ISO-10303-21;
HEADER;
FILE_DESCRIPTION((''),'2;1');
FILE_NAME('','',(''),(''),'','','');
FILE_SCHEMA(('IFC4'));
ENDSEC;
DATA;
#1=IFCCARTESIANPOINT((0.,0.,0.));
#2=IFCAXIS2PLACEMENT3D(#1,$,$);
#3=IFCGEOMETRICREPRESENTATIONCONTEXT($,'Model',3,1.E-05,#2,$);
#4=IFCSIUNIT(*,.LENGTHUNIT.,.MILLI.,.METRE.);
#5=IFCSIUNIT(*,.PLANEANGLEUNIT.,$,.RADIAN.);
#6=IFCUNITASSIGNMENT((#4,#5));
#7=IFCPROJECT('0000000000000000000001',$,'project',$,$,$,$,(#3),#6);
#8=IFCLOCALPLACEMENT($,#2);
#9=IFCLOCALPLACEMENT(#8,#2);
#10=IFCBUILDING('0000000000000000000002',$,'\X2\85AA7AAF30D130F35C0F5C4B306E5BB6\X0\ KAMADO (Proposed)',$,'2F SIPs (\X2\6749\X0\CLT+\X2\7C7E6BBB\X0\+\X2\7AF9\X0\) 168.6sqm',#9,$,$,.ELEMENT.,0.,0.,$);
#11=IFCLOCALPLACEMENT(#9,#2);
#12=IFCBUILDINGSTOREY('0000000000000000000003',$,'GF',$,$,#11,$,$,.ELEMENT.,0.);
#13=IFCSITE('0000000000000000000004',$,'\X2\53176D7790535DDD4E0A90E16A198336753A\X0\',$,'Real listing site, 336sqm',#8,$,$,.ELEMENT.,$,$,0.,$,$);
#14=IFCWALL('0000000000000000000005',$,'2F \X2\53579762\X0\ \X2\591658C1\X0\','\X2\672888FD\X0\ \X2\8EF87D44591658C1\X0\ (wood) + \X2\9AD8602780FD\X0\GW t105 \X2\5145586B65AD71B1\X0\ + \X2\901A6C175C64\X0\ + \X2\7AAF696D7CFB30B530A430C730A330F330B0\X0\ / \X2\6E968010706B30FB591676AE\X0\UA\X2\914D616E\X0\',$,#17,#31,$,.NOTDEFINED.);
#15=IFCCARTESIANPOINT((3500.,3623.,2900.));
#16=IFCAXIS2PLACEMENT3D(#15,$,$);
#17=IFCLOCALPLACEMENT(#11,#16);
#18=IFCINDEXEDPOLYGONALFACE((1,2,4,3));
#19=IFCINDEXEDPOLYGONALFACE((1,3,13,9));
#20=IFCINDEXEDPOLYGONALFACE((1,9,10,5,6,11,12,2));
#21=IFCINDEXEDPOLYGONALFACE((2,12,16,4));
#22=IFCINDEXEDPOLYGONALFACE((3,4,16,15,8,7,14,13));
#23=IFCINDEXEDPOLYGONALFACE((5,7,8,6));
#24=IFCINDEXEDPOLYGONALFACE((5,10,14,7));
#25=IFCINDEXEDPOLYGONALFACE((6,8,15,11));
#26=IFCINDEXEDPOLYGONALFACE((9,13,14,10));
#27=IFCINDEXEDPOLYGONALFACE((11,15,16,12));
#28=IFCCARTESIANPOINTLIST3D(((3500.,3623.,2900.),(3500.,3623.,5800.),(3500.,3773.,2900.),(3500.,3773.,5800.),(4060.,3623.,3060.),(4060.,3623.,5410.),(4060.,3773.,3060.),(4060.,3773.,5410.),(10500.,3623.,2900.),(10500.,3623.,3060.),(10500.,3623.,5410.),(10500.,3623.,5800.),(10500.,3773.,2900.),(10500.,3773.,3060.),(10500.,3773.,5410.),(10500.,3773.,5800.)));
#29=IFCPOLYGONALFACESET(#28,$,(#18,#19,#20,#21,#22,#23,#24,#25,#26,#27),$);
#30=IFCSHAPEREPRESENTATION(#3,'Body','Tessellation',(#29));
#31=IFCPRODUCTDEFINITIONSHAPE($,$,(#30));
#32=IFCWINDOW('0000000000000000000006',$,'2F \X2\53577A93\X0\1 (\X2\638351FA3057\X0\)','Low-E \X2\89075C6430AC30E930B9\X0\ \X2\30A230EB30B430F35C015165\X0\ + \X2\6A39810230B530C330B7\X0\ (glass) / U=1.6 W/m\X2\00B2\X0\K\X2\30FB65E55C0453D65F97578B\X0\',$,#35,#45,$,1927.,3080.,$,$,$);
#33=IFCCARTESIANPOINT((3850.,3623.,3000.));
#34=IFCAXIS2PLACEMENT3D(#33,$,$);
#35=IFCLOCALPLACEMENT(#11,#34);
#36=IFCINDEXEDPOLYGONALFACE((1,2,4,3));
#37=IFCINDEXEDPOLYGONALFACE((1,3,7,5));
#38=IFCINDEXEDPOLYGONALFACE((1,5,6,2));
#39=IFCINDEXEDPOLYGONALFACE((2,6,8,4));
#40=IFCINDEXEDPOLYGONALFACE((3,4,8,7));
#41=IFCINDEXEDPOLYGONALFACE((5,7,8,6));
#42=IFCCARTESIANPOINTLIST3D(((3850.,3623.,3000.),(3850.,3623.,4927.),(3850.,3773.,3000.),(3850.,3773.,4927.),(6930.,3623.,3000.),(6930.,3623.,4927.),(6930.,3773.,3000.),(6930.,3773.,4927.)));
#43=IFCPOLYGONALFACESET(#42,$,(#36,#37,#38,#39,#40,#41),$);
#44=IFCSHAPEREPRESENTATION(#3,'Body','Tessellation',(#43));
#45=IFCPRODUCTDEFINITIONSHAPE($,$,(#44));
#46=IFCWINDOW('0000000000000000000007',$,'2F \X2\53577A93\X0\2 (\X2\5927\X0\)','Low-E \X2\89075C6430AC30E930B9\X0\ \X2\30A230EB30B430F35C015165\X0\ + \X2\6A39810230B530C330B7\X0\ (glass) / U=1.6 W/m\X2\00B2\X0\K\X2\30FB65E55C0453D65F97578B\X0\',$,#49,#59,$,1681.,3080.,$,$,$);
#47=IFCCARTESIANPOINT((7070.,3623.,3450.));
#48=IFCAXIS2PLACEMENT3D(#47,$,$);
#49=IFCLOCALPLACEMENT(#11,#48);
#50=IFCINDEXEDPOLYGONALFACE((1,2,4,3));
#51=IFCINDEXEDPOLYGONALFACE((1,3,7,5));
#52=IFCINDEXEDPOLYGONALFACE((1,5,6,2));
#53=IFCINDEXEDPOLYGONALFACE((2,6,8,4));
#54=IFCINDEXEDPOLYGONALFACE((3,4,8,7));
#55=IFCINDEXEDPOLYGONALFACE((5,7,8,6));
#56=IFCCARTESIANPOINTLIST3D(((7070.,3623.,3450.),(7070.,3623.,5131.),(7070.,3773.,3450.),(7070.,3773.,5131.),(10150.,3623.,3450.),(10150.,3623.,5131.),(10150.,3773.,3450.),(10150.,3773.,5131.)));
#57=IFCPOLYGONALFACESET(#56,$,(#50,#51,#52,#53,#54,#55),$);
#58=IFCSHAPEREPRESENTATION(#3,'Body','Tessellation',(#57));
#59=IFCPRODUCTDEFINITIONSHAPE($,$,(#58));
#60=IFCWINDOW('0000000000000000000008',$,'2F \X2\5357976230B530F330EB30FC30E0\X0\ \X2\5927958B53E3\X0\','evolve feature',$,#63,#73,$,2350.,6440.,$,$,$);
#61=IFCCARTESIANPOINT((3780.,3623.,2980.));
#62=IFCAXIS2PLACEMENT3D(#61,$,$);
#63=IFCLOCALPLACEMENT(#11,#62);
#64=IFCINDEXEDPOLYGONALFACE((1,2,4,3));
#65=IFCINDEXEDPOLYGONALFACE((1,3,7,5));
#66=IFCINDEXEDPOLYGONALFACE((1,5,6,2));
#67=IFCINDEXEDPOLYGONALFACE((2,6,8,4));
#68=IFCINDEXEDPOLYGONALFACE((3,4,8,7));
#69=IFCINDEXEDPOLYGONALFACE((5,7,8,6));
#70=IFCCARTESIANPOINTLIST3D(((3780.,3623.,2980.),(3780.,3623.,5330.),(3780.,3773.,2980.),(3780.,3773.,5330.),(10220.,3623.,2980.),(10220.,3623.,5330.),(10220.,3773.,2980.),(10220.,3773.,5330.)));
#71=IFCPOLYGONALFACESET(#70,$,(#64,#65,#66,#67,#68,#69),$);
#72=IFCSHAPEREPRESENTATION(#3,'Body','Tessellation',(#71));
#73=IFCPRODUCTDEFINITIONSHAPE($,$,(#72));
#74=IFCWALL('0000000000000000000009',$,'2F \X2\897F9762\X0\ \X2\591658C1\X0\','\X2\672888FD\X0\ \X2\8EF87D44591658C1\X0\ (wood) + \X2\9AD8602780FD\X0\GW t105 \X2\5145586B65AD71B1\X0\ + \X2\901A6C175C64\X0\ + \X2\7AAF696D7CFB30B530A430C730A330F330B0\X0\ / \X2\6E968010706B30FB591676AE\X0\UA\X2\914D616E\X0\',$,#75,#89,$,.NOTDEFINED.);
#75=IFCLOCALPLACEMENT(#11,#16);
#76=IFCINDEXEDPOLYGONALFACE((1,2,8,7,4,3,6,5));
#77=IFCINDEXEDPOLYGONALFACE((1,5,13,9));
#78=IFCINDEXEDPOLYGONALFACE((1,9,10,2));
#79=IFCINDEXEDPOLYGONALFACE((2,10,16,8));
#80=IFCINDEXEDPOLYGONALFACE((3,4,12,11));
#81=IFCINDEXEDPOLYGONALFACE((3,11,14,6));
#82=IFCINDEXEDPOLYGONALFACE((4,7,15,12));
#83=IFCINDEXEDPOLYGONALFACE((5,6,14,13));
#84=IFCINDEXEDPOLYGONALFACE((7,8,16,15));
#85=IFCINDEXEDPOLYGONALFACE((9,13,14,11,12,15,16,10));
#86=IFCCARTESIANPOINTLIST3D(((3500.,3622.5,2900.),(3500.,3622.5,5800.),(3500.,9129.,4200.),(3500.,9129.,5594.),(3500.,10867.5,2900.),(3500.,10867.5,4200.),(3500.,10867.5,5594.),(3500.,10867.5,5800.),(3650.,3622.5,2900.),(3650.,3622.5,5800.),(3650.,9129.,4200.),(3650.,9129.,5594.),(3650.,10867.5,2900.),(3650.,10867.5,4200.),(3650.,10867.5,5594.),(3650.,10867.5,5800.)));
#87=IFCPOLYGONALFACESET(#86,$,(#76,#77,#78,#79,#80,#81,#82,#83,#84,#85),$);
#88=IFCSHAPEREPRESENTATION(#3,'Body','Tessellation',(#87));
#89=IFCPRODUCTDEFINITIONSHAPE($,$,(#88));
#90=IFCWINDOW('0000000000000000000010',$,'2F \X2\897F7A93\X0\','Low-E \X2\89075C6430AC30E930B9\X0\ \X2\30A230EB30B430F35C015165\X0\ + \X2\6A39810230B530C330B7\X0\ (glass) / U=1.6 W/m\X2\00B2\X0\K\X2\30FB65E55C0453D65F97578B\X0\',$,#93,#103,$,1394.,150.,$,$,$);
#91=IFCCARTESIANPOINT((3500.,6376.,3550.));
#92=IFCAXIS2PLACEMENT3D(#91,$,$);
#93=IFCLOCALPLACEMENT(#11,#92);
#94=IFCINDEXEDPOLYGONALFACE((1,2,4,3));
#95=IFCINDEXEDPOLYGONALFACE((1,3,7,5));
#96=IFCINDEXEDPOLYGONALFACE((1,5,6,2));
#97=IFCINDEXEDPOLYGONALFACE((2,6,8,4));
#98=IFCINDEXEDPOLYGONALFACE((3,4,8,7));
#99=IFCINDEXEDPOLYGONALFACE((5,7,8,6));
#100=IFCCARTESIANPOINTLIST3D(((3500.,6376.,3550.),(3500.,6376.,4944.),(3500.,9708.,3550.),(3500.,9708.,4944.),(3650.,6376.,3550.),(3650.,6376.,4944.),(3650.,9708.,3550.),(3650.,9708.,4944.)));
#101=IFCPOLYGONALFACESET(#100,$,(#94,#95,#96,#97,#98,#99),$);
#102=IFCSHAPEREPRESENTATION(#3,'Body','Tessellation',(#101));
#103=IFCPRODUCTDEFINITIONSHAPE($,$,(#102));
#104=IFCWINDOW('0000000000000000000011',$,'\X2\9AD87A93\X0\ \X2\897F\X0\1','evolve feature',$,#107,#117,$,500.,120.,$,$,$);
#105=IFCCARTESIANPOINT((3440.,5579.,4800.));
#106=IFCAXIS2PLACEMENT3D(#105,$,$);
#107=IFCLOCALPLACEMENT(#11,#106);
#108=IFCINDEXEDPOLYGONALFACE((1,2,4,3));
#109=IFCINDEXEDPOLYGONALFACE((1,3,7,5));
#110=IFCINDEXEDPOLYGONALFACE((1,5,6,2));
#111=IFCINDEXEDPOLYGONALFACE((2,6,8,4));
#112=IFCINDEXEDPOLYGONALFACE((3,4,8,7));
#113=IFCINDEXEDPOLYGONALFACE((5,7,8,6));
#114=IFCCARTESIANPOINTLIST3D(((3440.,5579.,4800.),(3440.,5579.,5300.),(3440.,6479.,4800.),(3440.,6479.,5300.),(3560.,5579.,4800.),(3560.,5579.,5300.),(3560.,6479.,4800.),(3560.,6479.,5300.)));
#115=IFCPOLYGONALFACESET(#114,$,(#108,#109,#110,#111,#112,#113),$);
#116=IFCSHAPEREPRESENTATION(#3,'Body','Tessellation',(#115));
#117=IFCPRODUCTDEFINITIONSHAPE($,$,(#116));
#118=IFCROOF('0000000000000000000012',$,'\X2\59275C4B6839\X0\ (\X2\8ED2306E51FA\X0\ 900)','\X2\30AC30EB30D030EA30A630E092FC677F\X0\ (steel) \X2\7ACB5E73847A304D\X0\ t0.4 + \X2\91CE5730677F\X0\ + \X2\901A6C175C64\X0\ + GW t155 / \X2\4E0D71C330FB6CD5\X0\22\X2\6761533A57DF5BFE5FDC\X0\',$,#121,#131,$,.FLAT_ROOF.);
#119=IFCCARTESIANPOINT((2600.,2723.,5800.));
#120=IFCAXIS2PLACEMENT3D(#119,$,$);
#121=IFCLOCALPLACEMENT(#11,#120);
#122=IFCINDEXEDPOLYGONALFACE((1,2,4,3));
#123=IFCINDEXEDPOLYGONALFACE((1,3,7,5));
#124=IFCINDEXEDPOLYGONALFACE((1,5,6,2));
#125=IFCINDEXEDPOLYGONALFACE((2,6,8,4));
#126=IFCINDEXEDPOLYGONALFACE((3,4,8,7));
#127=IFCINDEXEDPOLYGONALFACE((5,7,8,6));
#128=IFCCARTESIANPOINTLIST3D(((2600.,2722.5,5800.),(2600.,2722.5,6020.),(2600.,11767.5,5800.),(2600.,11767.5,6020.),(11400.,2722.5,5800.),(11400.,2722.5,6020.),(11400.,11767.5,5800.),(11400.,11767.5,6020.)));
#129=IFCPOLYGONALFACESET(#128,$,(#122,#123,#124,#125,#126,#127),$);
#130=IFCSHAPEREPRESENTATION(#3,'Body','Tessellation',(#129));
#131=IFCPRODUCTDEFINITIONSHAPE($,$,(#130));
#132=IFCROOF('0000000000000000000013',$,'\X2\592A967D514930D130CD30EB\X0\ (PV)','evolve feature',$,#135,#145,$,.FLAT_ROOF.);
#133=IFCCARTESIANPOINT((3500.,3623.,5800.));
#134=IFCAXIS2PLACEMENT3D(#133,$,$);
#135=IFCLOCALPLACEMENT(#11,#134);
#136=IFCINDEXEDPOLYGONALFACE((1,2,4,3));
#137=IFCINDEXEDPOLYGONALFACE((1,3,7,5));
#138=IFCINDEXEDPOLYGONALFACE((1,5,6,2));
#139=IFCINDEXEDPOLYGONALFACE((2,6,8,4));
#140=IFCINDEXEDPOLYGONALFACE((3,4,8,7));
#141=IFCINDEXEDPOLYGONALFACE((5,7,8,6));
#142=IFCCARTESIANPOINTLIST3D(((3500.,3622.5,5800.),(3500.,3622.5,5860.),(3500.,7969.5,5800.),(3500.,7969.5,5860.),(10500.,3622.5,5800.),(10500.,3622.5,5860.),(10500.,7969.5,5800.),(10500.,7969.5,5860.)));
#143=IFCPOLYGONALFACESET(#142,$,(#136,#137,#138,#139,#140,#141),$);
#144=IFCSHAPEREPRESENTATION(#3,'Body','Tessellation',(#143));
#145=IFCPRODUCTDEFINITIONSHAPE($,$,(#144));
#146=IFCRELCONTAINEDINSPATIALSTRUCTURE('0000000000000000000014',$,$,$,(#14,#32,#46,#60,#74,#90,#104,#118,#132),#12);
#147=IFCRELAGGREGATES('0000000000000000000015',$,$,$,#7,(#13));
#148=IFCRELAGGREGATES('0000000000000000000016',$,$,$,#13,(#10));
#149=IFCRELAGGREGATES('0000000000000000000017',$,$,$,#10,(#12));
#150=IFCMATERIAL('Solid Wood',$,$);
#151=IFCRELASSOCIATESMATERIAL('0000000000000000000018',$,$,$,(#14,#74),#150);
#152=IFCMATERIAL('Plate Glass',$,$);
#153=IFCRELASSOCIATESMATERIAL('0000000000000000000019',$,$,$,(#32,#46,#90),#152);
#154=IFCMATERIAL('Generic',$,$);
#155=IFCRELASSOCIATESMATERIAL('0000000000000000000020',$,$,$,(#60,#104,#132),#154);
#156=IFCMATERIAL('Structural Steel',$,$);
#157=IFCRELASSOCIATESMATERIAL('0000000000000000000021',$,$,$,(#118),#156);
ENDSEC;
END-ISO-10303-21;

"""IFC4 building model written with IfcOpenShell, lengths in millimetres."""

from ifc_helpers import new_model, si_unit, frame, frame_2d, origin, place, context, project, spatial, rectangle, extrude, material, element, fill, save


model = new_model("IFC4")

# Units and contexts
model_context = context("Model", 3, precision=1e-05, world=origin())
ifc_project = project(units=[si_unit("LENGTHUNIT", "METRE", prefix="MILLI"), si_unit("PLANEANGLEUNIT", "RADIAN")], contexts=[model_context])

# Site, building, storey
site_placement = place(None, origin())
site = spatial("IfcSite", under=ifc_project, at=site_placement, Name="北海道川上郡標茶町", ObjectType="Real listing site, 336sqm", CompositionType="ELEMENT", RefElevation=0.0)
building_placement = place(site_placement, origin())
building = spatial("IfcBuilding", under=site, at=building_placement, Name="薪窯パン小屋の家 KAMADO (Proposed)", ObjectType="2F SIPs (杉CLT+籾殻+竹) 168.6sqm", CompositionType="ELEMENT", ElevationOfRefHeight=0.0, ElevationOfTerrain=0.0)
storey_placement = place(building_placement, origin())
storey = spatial("IfcBuildingStorey", under=building, at=storey_placement, Name="GF", CompositionType="ELEMENT", Elevation=0.0)

# Shared definitions
ifc_material_1 = material(Name="Solid Wood")
ifc_material_2 = material(Name="Generic")

# Shared definitions
ifc_material_3 = material(Name="Plate Glass")

# Walls, openings, windows
wall_1_placement = place(storey_placement, frame((3500.0, 3623.0, 2900.0)))
wall_1 = element("IfcWall", 1, at=wall_1_placement, inside=storey, material=ifc_material_1, Name="2F 南面 外壁", Description="木製 軸組外壁 (wood) + 高性能GW t105 充填断熱 + 通気層 + 窯業系サイディング / 準耐火・外皮UA配慮", PredefinedType="NOTDEFINED", context=model_context, shape_type="SweptSolid", body=[
    extrude(rectangle(XDim=7000.0, YDim=150.0, at=frame_2d((3500.0, 75.0))), frame((3500.0, 3623.0, 2900.0)), (0.0, 0.0, 1.0), 2900.0),
])
opening_1_placement = place(storey_placement, frame((3850.0, 3623.0, 3000.0)))
opening_1 = element("IfcOpeningElement", 2, at=opening_1_placement, cuts=wall_1, PredefinedType="NOTDEFINED", context=model_context, shape_type="SweptSolid", body=[
    extrude(rectangle(XDim=3080.0, YDim=150.0, at=frame_2d((1540.0, 75.0))), frame((3850.0, 3623.0, 3000.0)), (0.0, 0.0, 1.0), 1927.0),
])
opening_2_placement = place(storey_placement, frame((7070.0, 3623.0, 3450.0)))
opening_2 = element("IfcOpeningElement", 3, at=opening_2_placement, cuts=wall_1, PredefinedType="NOTDEFINED", context=model_context, shape_type="SweptSolid", body=[
    extrude(rectangle(XDim=3080.0, YDim=150.0, at=frame_2d((1540.0, 75.0))), frame((7070.0, 3623.0, 3450.0)), (0.0, 0.0, 1.0), 1681.0),
])
opening_3_placement = place(storey_placement, frame((3780.0, 3623.0, 2980.0)))
opening_3 = element("IfcOpeningElement", 4, at=opening_3_placement, cuts=wall_1, PredefinedType="NOTDEFINED", context=model_context, shape_type="SweptSolid", body=[
    extrude(rectangle(XDim=6440.0, YDim=150.0, at=frame_2d((3220.0, 75.0))), frame((3780.0, 3623.0, 2980.0)), (0.0, 0.0, 1.0), 2350.0),
])
window_1_placement = place(storey_placement, frame((3850.0, 3623.0, 3000.0)))
window_1 = element("IfcWindow", 5, at=window_1_placement, inside=storey, material=ifc_material_3, Name="2F 南窓1 (掃出し)", Description="Low-E 複層ガラス アルゴン封入 + 樹脂サッシ (glass) / U=1.6 W/m²K・日射取得型", OverallHeight=1927.0, OverallWidth=3080.0, context=model_context, shape_type="SweptSolid", body=[
    extrude(rectangle(XDim=3080.0, YDim=150.0, at=frame_2d((1540.0, 75.0))), frame((3850.0, 3623.0, 3000.0)), (0.0, 0.0, 1.0), 1927.0),
])
fill(opening_1, window_1)
window_2_placement = place(storey_placement, frame((7070.0, 3623.0, 3450.0)))
window_2 = element("IfcWindow", 6, at=window_2_placement, inside=storey, material=ifc_material_3, Name="2F 南窓2 (大)", Description="Low-E 複層ガラス アルゴン封入 + 樹脂サッシ (glass) / U=1.6 W/m²K・日射取得型", OverallHeight=1681.0, OverallWidth=3080.0, context=model_context, shape_type="SweptSolid", body=[
    extrude(rectangle(XDim=3080.0, YDim=150.0, at=frame_2d((1540.0, 75.0))), frame((7070.0, 3623.0, 3450.0)), (0.0, 0.0, 1.0), 1681.0),
])
fill(opening_2, window_2)
window_3_placement = place(storey_placement, frame((3780.0, 3623.0, 2980.0)))
window_3 = element("IfcWindow", 7, at=window_3_placement, inside=storey, material=ifc_material_2, Name="2F 南面サンルーム 大開口", Description="evolve feature", OverallHeight=2350.0, OverallWidth=6440.0, context=model_context, shape_type="SweptSolid", body=[
    extrude(rectangle(XDim=6440.0, YDim=150.0, at=frame_2d((3220.0, 75.0))), frame((3780.0, 3623.0, 2980.0)), (0.0, 0.0, 1.0), 2350.0),
])
fill(opening_3, window_3)
wall_2_placement = place(storey_placement, frame((3500.0, 3623.0, 2900.0)))
wall_2 = element("IfcWall", 8, at=wall_2_placement, inside=storey, material=ifc_material_1, Name="2F 西面 外壁", Description="木製 軸組外壁 (wood) + 高性能GW t105 充填断熱 + 通気層 + 窯業系サイディング / 準耐火・外皮UA配慮", PredefinedType="NOTDEFINED", context=model_context, shape_type="SweptSolid", body=[
    extrude(rectangle(XDim=150.0, YDim=7245.0, at=frame_2d((75.0, 3622.0))), frame((3500.0, 3623.0, 2900.0)), (0.0, 0.0, 1.0), 2900.0),
])
opening_4_placement = place(storey_placement, frame((3500.0, 6376.0, 3550.0)))
opening_4 = element("IfcOpeningElement", 9, at=opening_4_placement, cuts=wall_2, PredefinedType="NOTDEFINED", context=model_context, shape_type="SweptSolid", body=[
    extrude(rectangle(XDim=150.0, YDim=3332.0, at=frame_2d((75.0, 1666.0))), frame((3500.0, 6376.0, 3550.0)), (0.0, 0.0, 1.0), 1394.0),
])
opening_5_placement = place(storey_placement, frame((3440.0, 5579.0, 4800.0)))
opening_5 = element("IfcOpeningElement", 10, at=opening_5_placement, cuts=wall_2, PredefinedType="NOTDEFINED", context=model_context, shape_type="SweptSolid", body=[
    extrude(rectangle(XDim=120.0, YDim=900.0, at=frame_2d((60.0, 450.0))), frame((3440.0, 5579.0, 4800.0)), (0.0, 0.0, 1.0), 500.0),
])
window_4_placement = place(storey_placement, frame((3500.0, 6376.0, 3550.0)))
window_4 = element("IfcWindow", 11, at=window_4_placement, inside=storey, material=ifc_material_3, Name="2F 西窓", Description="Low-E 複層ガラス アルゴン封入 + 樹脂サッシ (glass) / U=1.6 W/m²K・日射取得型", OverallHeight=1394.0, OverallWidth=150.0, context=model_context, shape_type="SweptSolid", body=[
    extrude(rectangle(XDim=150.0, YDim=3332.0, at=frame_2d((75.0, 1666.0))), frame((3500.0, 6376.0, 3550.0)), (0.0, 0.0, 1.0), 1394.0),
])
fill(opening_4, window_4)
window_5_placement = place(storey_placement, frame((3440.0, 5579.0, 4800.0)))
window_5 = element("IfcWindow", 12, at=window_5_placement, inside=storey, material=ifc_material_2, Name="高窓 西1", Description="evolve feature", OverallHeight=500.0, OverallWidth=120.0, context=model_context, shape_type="SweptSolid", body=[
    extrude(rectangle(XDim=120.0, YDim=900.0, at=frame_2d((60.0, 450.0))), frame((3440.0, 5579.0, 4800.0)), (0.0, 0.0, 1.0), 500.0),
])
fill(opening_5, window_5)

# Roofs
ifc_material_4 = material(Name="Structural Steel")
roof_1_placement = place(storey_placement, frame((2600.0, 2723.0, 5800.0)))
element("IfcRoof", 13, at=roof_1_placement, inside=storey, material=ifc_material_4, Name="大屋根 (軒の出 900)", Description="ガルバリウム鋼板 (steel) 立平葺き t0.4 + 野地板 + 通気層 + GW t155 / 不燃・法22条区域対応", PredefinedType="FLAT_ROOF", context=model_context, shape_type="SweptSolid", body=[
    extrude(rectangle(XDim=8800.0, YDim=9045.0, at=frame_2d((4400.0, 4522.0))), frame((2600.0, 2723.0, 5800.0)), (0.0, 0.0, 1.0), 220.0),
])
roof_2_placement = place(storey_placement, frame((3500.0, 3623.0, 5800.0)))
element("IfcRoof", 14, at=roof_2_placement, inside=storey, material=ifc_material_2, Name="太陽光パネル (PV)", Description="evolve feature", PredefinedType="FLAT_ROOF", context=model_context, shape_type="SweptSolid", body=[
    extrude(rectangle(XDim=7000.0, YDim=4347.0, at=frame_2d((3500.0, 2173.0))), frame((3500.0, 3623.0, 5800.0)), (0.0, 0.0, 1.0), 60.0),
])

save(model, "model.ifc")
